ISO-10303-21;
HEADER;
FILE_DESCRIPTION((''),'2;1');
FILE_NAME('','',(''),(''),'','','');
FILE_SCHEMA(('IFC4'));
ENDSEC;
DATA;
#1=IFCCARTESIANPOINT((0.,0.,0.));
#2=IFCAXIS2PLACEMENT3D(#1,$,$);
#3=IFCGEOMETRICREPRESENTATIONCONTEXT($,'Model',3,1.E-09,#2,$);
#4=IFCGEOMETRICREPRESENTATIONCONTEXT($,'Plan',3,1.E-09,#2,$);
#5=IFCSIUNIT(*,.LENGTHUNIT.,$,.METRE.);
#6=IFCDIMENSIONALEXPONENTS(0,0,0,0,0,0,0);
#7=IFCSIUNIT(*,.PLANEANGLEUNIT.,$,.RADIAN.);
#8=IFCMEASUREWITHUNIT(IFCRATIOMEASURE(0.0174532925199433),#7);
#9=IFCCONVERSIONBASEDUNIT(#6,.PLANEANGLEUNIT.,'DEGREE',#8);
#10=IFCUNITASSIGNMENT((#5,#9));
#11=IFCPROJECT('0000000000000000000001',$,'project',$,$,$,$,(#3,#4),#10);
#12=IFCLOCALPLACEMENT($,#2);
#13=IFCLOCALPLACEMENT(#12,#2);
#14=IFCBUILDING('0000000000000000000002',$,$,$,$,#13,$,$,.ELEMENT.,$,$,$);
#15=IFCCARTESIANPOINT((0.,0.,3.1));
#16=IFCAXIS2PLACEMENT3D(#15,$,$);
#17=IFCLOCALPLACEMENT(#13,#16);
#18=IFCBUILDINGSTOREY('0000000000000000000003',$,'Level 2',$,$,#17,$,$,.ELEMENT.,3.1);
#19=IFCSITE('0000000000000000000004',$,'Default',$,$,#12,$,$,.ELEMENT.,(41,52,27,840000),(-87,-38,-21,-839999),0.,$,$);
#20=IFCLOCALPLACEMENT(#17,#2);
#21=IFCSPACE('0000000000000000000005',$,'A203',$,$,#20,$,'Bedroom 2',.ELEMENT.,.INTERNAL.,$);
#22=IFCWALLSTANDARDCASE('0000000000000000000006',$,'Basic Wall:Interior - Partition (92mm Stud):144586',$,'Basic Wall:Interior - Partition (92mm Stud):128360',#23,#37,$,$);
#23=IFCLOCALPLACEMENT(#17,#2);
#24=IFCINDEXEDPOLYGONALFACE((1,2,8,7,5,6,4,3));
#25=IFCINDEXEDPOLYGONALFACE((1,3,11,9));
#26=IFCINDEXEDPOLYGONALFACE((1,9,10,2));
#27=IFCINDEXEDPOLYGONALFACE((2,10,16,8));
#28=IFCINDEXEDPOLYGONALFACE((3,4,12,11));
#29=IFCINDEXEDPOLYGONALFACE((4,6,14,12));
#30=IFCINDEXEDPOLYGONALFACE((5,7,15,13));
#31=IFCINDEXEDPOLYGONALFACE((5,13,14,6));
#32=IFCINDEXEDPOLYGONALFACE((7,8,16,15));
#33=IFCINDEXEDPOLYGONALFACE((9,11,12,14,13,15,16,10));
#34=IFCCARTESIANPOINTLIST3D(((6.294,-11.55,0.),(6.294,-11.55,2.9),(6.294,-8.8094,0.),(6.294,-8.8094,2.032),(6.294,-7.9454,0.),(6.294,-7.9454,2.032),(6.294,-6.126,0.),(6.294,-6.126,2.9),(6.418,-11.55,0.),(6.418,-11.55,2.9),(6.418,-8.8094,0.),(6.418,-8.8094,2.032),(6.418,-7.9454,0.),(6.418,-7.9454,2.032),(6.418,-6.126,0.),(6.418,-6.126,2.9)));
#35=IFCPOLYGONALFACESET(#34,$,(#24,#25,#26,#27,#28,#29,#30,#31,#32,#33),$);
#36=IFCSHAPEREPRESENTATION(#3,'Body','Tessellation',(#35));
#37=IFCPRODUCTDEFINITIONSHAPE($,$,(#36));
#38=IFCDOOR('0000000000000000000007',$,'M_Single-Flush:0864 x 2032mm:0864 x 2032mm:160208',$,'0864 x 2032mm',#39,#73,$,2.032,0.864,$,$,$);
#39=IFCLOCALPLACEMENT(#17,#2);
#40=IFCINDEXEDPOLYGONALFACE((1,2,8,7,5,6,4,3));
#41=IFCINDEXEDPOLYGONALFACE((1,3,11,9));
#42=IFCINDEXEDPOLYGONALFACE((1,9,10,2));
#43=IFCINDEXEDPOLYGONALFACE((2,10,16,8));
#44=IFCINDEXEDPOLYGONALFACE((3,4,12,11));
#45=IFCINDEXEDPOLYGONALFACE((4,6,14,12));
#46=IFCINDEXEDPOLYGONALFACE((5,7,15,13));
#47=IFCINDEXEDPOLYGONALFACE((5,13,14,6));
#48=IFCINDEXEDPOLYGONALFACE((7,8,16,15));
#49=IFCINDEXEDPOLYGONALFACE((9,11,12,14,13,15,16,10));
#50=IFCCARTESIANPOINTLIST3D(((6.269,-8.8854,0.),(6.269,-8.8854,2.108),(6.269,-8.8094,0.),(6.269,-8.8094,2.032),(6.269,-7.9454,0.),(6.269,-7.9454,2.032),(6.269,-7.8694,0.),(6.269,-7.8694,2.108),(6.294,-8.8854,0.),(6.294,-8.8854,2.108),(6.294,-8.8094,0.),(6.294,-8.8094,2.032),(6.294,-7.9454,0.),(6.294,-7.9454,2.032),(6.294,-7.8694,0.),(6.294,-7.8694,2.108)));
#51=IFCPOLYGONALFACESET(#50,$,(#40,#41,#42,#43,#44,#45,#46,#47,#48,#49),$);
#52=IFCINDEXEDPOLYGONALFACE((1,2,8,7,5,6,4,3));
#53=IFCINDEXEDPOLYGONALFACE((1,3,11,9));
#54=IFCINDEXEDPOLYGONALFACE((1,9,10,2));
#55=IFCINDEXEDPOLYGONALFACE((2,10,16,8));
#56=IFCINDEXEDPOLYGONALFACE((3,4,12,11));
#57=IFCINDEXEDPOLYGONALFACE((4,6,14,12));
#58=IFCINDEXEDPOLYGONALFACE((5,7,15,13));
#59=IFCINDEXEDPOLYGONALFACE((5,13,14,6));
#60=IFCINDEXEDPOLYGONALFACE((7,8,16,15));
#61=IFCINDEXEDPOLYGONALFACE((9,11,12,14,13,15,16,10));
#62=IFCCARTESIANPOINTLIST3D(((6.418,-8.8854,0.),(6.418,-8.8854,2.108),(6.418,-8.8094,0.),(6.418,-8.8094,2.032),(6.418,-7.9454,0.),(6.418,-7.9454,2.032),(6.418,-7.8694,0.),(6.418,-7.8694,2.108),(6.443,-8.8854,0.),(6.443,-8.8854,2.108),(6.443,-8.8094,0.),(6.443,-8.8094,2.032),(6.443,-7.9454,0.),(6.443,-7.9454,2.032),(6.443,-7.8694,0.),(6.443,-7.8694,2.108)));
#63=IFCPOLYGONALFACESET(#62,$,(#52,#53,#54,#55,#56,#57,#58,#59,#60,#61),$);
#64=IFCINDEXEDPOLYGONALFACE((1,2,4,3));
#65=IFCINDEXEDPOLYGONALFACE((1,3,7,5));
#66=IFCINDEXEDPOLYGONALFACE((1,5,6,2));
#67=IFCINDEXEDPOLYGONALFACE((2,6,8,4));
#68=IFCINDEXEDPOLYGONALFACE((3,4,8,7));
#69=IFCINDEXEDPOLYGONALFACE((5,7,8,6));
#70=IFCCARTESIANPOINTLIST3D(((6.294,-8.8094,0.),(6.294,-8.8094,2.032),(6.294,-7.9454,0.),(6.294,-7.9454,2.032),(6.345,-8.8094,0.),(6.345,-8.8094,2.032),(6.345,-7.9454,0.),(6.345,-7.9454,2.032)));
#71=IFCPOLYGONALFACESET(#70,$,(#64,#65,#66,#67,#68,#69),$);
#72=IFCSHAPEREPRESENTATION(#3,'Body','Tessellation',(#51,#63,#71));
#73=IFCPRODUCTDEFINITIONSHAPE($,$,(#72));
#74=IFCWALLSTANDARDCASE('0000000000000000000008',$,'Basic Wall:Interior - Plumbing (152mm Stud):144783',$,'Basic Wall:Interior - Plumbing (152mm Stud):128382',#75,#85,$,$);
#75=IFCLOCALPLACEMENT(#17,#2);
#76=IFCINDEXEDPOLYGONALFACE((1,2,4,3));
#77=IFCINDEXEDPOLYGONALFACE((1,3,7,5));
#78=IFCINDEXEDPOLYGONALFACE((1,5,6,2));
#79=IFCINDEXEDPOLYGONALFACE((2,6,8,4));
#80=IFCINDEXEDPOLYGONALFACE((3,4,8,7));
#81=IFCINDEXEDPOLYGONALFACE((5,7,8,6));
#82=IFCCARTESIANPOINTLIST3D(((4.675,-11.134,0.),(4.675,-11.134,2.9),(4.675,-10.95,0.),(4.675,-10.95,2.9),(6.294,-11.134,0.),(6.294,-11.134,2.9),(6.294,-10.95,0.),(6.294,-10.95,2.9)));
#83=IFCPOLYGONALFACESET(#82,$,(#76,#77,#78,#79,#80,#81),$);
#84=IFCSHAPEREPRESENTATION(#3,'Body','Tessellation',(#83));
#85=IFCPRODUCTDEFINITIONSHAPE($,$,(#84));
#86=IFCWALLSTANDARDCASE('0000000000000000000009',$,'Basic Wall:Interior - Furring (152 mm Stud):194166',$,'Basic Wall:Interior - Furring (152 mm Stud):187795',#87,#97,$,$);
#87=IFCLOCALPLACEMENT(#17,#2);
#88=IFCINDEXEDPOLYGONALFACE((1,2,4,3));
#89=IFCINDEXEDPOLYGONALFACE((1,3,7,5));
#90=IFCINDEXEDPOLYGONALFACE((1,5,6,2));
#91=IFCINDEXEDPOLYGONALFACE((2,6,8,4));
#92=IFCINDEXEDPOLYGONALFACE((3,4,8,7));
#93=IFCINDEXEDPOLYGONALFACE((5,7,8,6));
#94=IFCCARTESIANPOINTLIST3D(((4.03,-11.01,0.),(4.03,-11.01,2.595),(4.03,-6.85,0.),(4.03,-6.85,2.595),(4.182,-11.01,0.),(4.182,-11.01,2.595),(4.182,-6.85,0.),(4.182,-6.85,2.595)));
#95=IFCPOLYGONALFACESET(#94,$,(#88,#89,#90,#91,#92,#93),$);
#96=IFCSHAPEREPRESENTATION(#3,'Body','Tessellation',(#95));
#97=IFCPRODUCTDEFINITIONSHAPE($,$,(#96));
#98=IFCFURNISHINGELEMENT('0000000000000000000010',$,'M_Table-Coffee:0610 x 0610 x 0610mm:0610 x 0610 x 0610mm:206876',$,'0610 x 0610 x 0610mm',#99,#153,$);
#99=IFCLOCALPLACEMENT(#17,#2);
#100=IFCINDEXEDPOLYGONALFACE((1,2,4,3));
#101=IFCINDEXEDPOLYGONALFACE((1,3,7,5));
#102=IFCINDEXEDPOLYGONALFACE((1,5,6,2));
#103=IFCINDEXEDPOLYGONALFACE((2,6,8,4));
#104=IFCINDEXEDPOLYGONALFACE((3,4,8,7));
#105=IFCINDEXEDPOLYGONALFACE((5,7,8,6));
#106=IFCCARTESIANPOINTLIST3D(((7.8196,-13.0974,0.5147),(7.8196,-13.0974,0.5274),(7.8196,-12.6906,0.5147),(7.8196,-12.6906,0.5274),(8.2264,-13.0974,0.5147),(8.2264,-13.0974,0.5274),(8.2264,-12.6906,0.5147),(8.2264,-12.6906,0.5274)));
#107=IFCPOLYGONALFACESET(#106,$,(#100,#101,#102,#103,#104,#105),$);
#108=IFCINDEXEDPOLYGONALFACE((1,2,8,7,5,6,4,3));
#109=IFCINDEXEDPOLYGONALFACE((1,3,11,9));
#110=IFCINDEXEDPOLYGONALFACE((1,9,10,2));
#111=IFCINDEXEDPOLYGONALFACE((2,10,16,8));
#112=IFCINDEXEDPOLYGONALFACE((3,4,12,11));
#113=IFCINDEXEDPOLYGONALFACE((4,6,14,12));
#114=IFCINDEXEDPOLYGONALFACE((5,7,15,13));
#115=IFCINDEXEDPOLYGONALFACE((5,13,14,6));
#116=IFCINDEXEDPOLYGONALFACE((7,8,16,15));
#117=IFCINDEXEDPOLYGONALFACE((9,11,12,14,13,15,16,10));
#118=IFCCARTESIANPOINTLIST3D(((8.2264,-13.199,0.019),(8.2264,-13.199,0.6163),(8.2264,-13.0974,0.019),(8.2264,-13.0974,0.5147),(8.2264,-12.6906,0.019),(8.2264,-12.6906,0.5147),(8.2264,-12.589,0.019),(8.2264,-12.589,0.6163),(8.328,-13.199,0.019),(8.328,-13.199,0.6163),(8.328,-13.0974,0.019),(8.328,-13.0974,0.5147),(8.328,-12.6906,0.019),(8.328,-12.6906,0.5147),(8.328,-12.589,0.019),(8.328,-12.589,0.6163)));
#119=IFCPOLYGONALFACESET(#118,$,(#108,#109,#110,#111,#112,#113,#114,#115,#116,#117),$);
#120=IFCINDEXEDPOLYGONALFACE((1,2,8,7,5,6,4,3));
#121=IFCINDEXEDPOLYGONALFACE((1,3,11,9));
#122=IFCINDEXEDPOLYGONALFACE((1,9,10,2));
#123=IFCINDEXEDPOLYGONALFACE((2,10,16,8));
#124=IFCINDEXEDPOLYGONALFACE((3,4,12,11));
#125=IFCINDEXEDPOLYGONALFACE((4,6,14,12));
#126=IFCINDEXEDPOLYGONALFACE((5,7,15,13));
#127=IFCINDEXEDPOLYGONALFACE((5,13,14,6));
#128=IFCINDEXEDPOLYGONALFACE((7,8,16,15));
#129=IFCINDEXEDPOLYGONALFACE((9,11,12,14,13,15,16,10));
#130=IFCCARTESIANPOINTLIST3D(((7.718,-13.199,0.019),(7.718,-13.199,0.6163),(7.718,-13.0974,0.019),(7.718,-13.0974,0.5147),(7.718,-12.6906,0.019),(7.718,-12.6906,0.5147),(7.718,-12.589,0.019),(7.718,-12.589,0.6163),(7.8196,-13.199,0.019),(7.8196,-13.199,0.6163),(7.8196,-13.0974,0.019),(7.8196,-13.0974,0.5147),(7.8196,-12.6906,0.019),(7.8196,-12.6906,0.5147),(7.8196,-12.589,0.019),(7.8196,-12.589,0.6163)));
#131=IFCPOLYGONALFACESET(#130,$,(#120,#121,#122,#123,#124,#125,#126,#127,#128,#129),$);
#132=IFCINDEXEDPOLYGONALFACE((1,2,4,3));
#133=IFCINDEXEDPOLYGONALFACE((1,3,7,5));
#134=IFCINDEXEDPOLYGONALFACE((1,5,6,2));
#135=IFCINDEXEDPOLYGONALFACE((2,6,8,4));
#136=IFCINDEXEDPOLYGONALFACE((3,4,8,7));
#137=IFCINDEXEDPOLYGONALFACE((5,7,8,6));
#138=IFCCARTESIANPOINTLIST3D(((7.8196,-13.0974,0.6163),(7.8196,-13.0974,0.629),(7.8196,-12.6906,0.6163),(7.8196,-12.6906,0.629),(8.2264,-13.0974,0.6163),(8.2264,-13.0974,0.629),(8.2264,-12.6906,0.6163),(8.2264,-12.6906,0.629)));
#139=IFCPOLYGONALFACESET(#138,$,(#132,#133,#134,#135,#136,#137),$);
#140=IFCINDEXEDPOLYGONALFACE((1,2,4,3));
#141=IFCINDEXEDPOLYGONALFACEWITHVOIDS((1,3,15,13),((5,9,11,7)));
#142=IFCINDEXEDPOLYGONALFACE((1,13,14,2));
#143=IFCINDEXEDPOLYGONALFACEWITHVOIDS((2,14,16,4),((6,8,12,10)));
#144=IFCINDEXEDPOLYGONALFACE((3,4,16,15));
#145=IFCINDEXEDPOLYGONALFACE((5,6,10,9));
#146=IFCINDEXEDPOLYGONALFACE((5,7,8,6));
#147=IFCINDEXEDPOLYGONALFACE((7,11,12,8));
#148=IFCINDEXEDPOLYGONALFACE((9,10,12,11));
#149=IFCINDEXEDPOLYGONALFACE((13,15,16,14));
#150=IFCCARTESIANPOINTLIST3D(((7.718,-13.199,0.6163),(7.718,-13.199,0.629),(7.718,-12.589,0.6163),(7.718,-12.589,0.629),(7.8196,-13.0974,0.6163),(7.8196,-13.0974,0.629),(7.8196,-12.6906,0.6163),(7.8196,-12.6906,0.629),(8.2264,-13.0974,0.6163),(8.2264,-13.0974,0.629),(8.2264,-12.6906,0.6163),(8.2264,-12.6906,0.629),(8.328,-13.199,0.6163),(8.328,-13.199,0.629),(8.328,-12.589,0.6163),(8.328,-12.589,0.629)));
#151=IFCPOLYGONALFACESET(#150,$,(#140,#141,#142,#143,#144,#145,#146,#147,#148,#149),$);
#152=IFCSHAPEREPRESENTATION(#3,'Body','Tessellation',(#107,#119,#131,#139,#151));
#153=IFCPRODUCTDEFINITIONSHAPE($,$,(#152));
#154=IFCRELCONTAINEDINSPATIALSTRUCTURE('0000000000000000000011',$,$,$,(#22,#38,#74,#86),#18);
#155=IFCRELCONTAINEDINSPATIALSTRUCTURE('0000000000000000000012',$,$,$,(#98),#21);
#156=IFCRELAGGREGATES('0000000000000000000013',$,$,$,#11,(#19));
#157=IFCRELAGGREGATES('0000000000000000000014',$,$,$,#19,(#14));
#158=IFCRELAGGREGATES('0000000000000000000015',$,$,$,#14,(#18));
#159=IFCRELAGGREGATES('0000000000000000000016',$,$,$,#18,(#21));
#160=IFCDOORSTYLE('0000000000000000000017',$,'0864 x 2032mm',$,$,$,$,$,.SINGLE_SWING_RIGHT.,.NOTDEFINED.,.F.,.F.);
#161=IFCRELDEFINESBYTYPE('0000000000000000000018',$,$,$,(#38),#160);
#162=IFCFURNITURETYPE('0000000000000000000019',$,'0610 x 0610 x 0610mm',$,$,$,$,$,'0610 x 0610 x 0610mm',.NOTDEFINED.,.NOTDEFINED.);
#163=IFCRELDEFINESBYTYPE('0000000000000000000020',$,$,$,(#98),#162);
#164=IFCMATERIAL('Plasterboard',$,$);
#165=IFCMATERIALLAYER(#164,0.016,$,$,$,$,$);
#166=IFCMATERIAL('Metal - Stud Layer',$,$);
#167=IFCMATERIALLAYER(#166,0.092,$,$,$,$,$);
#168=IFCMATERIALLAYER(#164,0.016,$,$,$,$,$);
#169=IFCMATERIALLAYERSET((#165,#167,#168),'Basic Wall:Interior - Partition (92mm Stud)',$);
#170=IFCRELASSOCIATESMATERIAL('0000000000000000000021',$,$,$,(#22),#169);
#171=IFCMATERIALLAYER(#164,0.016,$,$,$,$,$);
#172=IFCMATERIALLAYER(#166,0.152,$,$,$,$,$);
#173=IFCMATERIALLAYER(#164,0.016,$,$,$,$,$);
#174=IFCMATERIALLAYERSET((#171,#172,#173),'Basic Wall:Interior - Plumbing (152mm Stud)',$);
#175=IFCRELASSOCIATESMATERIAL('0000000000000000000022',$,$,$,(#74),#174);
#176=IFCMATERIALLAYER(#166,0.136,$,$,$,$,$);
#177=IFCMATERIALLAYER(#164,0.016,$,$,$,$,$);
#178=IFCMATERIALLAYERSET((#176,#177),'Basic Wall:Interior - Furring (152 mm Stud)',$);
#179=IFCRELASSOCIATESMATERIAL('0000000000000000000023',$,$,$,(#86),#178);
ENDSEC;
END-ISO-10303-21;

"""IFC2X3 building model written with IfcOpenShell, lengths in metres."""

from ifc_helpers import new_model, entity, si_unit, converted_unit, frame, frame_2d, origin, origin_2d_with_axis, place, context, project, spatial, polyline, rectangle, outline, extrude, source, transform, mapped, material, layer, layer_set, layer_usage, type_object, type_shapes, element, fill, save


model = new_model("IFC2X3")

# Units and contexts
model_context = context("Model", 3, precision=1e-09, world=origin())
plan_context = context("Plan", 3, precision=1e-09, world=origin())
ifc_project = project(units=[si_unit("LENGTHUNIT", "METRE"), converted_unit("PLANEANGLEUNIT", "DEGREE", entity("IfcRatioMeasure", 0.0174532925199433), si_unit("PLANEANGLEUNIT", "RADIAN"), dimensions=[0, 0, 0, 0, 0, 0, 0])], contexts=[model_context, plan_context])

# Site, building, storey
site_placement = place(None, origin())
site = spatial("IfcSite", under=ifc_project, at=site_placement, Name="Default", CompositionType="ELEMENT", RefLatitude=(41, 52, 27, 840000), RefLongitude=(-87, -38, -21, -839999), RefElevation=0.0)
building_placement = place(site_placement, origin())
building = spatial("IfcBuilding", under=site, at=building_placement, CompositionType="ELEMENT")
storey_placement = place(building_placement, frame((0.0, 0.0, 3.1)))
storey = spatial("IfcBuildingStorey", under=building, at=storey_placement, Name="Level 2", CompositionType="ELEMENT", Elevation=3.1)

# Shared definitions
ifc_material_1 = material(Name="Metal - Stud Layer")
ifc_material_2 = material(Name="Plasterboard")

# Shared definitions
ifc_layer_1 = layer(ifc_material_2, 0.016)
ifc_layer_2 = layer(ifc_material_1, 0.092)
ifc_layer_3 = layer(ifc_material_2, 0.016)
ifc_layer_set_1 = layer_set([ifc_layer_1, ifc_layer_2, ifc_layer_3], Name="Basic Wall:Interior - Partition (92mm Stud)")

# Wall, opening, door
ifc_layer_usage_1 = layer_usage(ifc_layer_set_1, "AXIS2", "NEGATIVE", 0.062)
wall_1_placement = place(storey_placement, frame((6.356, -11.55, 0.0), z_axis=(0.0, 0.0, 1.0), x_axis=(0.0, 1.0, 0.0)))
wall_1 = element("IfcWallStandardCase", 1, at=wall_1_placement, inside=storey, material=ifc_layer_usage_1, Name="Basic Wall:Interior - Partition (92mm Stud):144586", ObjectType="Basic Wall:Interior - Partition (92mm Stud):128360", context=model_context, shape_type="SweptSolid", body=[
    extrude(rectangle(XDim=5.424, YDim=0.124, at=frame_2d((2.712, 0.0), x_axis=(-1.0, 0.0))), origin(), (0.0, 0.0, 1.0), 2.9),
])
opening_1_placement = place(wall_1_placement, frame((2.7406, -0.062, 0.0)))
opening_1 = element("IfcOpeningElement", 2, at=opening_1_placement, cuts=wall_1, ObjectType="Opening", context=model_context, shape_type="SweptSolid", body=[
    extrude(rectangle(XDim=0.864, YDim=2.032, at=frame_2d((1.016, 0.432), x_axis=(0.0, 1.0))), frame((0.0, 0.0, 0.0), z_axis=(0.0, 1.0, 0.0), x_axis=(0.0, 0.0, 1.0)), (0.0, 0.0, 1.0), 0.124),
])
door_style = type_object("IfcDoorStyle", Name="0864 x 2032mm", ConstructionType="NOTDEFINED", OperationType="SINGLE_SWING_RIGHT", ParameterTakesPrecedence=False, Sizeable=False)
shared_shape_1 = source(origin(), model_context, "Body", "SweptSolid", [
    extrude(outline(polyline([(-0.508, -1.073), (0.508, -1.073), (0.508, 1.035), (0.432, 1.035), (0.432, -0.997), (-0.432, -0.997), (-0.432, 1.035), (-0.508, 1.035), (-0.508, -1.073)])), frame((0.432, 0.124, 1.035), z_axis=(0.0, 1.0, 0.0), x_axis=(1.0, 0.0, 0.0)), (0.0, 0.0, 1.0), 0.025),
    extrude(outline(polyline([(-1.073, -0.508), (1.035, -0.508), (1.035, -0.432), (-0.997, -0.432), (-0.997, 0.432), (1.035, 0.432), (1.035, 0.508), (-1.073, 0.508), (-1.073, -0.508)])), frame((0.432, -0.025, 1.035), z_axis=(0.0, 1.0, 0.0), x_axis=(0.0, 0.0, -1.0)), (0.0, 0.0, 1.0), 0.025),
    extrude(rectangle(XDim=0.051, YDim=0.864, at=origin_2d_with_axis()), frame((0.432, 0.0985, 0.0), z_axis=(0.0, 0.0, 1.0), x_axis=(0.0, 1.0, 0.0)), (0.0, 0.0, 1.0), 2.032),
])
type_shapes(door_style, [shared_shape_1])
door_placement = place(opening_1_placement, origin())
door = element("IfcDoor", 3, at=door_placement, inside=storey, type_object=door_style, Name="M_Single-Flush:0864 x 2032mm:0864 x 2032mm:160208", ObjectType="0864 x 2032mm", OverallHeight=2.032, OverallWidth=0.864, context=model_context, shape_type="MappedRepresentation", body=[
    mapped(shared_shape_1, transform((0.0, 0.0, 0.0), scale=1.0)),
])
fill(opening_1, door)

# Walls
ifc_layer_4 = layer(ifc_material_2, 0.016)
ifc_layer_5 = layer(ifc_material_1, 0.152)
ifc_layer_6 = layer(ifc_material_2, 0.016)
ifc_layer_set_2 = layer_set([ifc_layer_4, ifc_layer_5, ifc_layer_6], Name="Basic Wall:Interior - Plumbing (152mm Stud)")
ifc_layer_usage_2 = layer_usage(ifc_layer_set_2, "AXIS2", "NEGATIVE", 0.092)
wall_2_placement = place(storey_placement, frame((6.294, -11.042, 0.0), z_axis=(0.0, 0.0, 1.0), x_axis=(-1.0, 0.0, 0.0)))
element("IfcWallStandardCase", 4, at=wall_2_placement, inside=storey, material=ifc_layer_usage_2, Name="Basic Wall:Interior - Plumbing (152mm Stud):144783", ObjectType="Basic Wall:Interior - Plumbing (152mm Stud):128382", context=model_context, shape_type="SweptSolid", body=[
    extrude(rectangle(XDim=1.619, YDim=0.184, at=frame_2d((0.8095, 0.0), x_axis=(-1.0, 0.0))), origin(), (0.0, 0.0, 1.0), 2.9),
])
ifc_layer_7 = layer(ifc_material_1, 0.136)
ifc_layer_8 = layer(ifc_material_2, 0.016)
ifc_layer_set_3 = layer_set([ifc_layer_7, ifc_layer_8], Name="Basic Wall:Interior - Furring (152 mm Stud)")
ifc_layer_usage_3 = layer_usage(ifc_layer_set_3, "AXIS2", "POSITIVE", -0.076)
wall_3_placement = place(storey_placement, frame((4.106, -11.01, 0.0), z_axis=(0.0, 0.0, 1.0), x_axis=(0.0, 1.0, 0.0)))
element("IfcWallStandardCase", 5, at=wall_3_placement, inside=storey, material=ifc_layer_usage_3, Name="Basic Wall:Interior - Furring (152 mm Stud):194166", ObjectType="Basic Wall:Interior - Furring (152 mm Stud):187795", context=model_context, shape_type="SweptSolid", body=[
    extrude(rectangle(XDim=4.16, YDim=0.152, at=frame_2d((2.08, 0.0), x_axis=(-1.0, 0.0))), origin(), (0.0, 0.0, 1.0), 2.595),
])

# Shared definitions
space_placement = place(storey_placement, origin())
space = spatial("IfcSpace", under=storey, at=space_placement, Name="A203", LongName="Bedroom 2", CompositionType="ELEMENT", InteriorOrExteriorSpace="INTERNAL")

# Furnishing element
furniture_type = type_object("IfcFurnitureType", Name="0610 x 0610 x 0610mm", ElementType="0610 x 0610 x 0610mm", AssemblyPlace="NOTDEFINED")
shared_shape_2 = source(origin(), model_context, "Body", "SweptSolid", [
    extrude(rectangle(XDim=0.4068, YDim=0.4068, at=origin_2d_with_axis()), frame((0.0183, 0.0952, 0.4957), z_axis=(0.0, 0.0, 1.0), x_axis=(-1.0, 0.0, 0.0)), (0.0, 0.0, 1.0), 0.0127),
    extrude(outline(polyline([(-0.2732, -0.305), (0.324, -0.305), (0.324, 0.305), (-0.2732, 0.305), (-0.2732, 0.2034), (0.2225, 0.2034), (0.2225, -0.2034), (-0.2732, -0.2034), (-0.2732, -0.305)])), frame((0.2217, 0.0952, 0.2732), z_axis=(1.0, 0.0, 0.0), x_axis=(0.0, 0.0, 1.0)), (0.0, 0.0, 1.0), 0.1016),
    extrude(outline(polyline([(-0.305, -0.3241), (0.305, -0.3241), (0.305, 0.2733), (0.2034, 0.2733), (0.2034, -0.2224), (-0.2034, -0.2224), (-0.2034, 0.2733), (-0.305, 0.2733), (-0.305, -0.3241)])), frame((-0.2867, 0.0952, 0.2733), z_axis=(1.0, 0.0, 0.0), x_axis=(0.0, -1.0, 0.0)), (0.0, 0.0, 1.0), 0.1016),
    extrude(rectangle(XDim=0.4068, YDim=0.4068, at=origin_2d_with_axis()), frame((0.0183, 0.0952, 0.5973), z_axis=(0.0, 0.0, 1.0), x_axis=(-1.0, 0.0, 0.0)), (0.0, 0.0, 1.0), 0.0127),
    extrude(outline(polyline([(-0.305, -0.305), (0.305, -0.305), (0.305, 0.305), (-0.305, 0.305), (-0.305, -0.305)]), holes=[polyline([(-0.2034, -0.2034), (-0.2034, 0.2034), (0.2034, 0.2034), (0.2034, -0.2034), (-0.2034, -0.2034)])]), frame((0.0183, 0.0952, 0.5973), z_axis=(0.0, 0.0, 1.0), x_axis=(-1.0, 0.0, 0.0)), (0.0, 0.0, 1.0), 0.0127),
])
type_shapes(furniture_type, [shared_shape_2])
furnishing_placement = place(space_placement, frame((8.0047, -12.9892, 0.019)))
element("IfcFurnishingElement", 6, at=furnishing_placement, inside=space, type_object=furniture_type, Name="M_Table-Coffee:0610 x 0610 x 0610mm:0610 x 0610 x 0610mm:206876", ObjectType="0610 x 0610 x 0610mm", context=model_context, shape_type="MappedRepresentation", body=[
    mapped(shared_shape_2, transform((0.0, 0.0, 0.0), scale=1.0)),
])

save(model, "model.ifc")
